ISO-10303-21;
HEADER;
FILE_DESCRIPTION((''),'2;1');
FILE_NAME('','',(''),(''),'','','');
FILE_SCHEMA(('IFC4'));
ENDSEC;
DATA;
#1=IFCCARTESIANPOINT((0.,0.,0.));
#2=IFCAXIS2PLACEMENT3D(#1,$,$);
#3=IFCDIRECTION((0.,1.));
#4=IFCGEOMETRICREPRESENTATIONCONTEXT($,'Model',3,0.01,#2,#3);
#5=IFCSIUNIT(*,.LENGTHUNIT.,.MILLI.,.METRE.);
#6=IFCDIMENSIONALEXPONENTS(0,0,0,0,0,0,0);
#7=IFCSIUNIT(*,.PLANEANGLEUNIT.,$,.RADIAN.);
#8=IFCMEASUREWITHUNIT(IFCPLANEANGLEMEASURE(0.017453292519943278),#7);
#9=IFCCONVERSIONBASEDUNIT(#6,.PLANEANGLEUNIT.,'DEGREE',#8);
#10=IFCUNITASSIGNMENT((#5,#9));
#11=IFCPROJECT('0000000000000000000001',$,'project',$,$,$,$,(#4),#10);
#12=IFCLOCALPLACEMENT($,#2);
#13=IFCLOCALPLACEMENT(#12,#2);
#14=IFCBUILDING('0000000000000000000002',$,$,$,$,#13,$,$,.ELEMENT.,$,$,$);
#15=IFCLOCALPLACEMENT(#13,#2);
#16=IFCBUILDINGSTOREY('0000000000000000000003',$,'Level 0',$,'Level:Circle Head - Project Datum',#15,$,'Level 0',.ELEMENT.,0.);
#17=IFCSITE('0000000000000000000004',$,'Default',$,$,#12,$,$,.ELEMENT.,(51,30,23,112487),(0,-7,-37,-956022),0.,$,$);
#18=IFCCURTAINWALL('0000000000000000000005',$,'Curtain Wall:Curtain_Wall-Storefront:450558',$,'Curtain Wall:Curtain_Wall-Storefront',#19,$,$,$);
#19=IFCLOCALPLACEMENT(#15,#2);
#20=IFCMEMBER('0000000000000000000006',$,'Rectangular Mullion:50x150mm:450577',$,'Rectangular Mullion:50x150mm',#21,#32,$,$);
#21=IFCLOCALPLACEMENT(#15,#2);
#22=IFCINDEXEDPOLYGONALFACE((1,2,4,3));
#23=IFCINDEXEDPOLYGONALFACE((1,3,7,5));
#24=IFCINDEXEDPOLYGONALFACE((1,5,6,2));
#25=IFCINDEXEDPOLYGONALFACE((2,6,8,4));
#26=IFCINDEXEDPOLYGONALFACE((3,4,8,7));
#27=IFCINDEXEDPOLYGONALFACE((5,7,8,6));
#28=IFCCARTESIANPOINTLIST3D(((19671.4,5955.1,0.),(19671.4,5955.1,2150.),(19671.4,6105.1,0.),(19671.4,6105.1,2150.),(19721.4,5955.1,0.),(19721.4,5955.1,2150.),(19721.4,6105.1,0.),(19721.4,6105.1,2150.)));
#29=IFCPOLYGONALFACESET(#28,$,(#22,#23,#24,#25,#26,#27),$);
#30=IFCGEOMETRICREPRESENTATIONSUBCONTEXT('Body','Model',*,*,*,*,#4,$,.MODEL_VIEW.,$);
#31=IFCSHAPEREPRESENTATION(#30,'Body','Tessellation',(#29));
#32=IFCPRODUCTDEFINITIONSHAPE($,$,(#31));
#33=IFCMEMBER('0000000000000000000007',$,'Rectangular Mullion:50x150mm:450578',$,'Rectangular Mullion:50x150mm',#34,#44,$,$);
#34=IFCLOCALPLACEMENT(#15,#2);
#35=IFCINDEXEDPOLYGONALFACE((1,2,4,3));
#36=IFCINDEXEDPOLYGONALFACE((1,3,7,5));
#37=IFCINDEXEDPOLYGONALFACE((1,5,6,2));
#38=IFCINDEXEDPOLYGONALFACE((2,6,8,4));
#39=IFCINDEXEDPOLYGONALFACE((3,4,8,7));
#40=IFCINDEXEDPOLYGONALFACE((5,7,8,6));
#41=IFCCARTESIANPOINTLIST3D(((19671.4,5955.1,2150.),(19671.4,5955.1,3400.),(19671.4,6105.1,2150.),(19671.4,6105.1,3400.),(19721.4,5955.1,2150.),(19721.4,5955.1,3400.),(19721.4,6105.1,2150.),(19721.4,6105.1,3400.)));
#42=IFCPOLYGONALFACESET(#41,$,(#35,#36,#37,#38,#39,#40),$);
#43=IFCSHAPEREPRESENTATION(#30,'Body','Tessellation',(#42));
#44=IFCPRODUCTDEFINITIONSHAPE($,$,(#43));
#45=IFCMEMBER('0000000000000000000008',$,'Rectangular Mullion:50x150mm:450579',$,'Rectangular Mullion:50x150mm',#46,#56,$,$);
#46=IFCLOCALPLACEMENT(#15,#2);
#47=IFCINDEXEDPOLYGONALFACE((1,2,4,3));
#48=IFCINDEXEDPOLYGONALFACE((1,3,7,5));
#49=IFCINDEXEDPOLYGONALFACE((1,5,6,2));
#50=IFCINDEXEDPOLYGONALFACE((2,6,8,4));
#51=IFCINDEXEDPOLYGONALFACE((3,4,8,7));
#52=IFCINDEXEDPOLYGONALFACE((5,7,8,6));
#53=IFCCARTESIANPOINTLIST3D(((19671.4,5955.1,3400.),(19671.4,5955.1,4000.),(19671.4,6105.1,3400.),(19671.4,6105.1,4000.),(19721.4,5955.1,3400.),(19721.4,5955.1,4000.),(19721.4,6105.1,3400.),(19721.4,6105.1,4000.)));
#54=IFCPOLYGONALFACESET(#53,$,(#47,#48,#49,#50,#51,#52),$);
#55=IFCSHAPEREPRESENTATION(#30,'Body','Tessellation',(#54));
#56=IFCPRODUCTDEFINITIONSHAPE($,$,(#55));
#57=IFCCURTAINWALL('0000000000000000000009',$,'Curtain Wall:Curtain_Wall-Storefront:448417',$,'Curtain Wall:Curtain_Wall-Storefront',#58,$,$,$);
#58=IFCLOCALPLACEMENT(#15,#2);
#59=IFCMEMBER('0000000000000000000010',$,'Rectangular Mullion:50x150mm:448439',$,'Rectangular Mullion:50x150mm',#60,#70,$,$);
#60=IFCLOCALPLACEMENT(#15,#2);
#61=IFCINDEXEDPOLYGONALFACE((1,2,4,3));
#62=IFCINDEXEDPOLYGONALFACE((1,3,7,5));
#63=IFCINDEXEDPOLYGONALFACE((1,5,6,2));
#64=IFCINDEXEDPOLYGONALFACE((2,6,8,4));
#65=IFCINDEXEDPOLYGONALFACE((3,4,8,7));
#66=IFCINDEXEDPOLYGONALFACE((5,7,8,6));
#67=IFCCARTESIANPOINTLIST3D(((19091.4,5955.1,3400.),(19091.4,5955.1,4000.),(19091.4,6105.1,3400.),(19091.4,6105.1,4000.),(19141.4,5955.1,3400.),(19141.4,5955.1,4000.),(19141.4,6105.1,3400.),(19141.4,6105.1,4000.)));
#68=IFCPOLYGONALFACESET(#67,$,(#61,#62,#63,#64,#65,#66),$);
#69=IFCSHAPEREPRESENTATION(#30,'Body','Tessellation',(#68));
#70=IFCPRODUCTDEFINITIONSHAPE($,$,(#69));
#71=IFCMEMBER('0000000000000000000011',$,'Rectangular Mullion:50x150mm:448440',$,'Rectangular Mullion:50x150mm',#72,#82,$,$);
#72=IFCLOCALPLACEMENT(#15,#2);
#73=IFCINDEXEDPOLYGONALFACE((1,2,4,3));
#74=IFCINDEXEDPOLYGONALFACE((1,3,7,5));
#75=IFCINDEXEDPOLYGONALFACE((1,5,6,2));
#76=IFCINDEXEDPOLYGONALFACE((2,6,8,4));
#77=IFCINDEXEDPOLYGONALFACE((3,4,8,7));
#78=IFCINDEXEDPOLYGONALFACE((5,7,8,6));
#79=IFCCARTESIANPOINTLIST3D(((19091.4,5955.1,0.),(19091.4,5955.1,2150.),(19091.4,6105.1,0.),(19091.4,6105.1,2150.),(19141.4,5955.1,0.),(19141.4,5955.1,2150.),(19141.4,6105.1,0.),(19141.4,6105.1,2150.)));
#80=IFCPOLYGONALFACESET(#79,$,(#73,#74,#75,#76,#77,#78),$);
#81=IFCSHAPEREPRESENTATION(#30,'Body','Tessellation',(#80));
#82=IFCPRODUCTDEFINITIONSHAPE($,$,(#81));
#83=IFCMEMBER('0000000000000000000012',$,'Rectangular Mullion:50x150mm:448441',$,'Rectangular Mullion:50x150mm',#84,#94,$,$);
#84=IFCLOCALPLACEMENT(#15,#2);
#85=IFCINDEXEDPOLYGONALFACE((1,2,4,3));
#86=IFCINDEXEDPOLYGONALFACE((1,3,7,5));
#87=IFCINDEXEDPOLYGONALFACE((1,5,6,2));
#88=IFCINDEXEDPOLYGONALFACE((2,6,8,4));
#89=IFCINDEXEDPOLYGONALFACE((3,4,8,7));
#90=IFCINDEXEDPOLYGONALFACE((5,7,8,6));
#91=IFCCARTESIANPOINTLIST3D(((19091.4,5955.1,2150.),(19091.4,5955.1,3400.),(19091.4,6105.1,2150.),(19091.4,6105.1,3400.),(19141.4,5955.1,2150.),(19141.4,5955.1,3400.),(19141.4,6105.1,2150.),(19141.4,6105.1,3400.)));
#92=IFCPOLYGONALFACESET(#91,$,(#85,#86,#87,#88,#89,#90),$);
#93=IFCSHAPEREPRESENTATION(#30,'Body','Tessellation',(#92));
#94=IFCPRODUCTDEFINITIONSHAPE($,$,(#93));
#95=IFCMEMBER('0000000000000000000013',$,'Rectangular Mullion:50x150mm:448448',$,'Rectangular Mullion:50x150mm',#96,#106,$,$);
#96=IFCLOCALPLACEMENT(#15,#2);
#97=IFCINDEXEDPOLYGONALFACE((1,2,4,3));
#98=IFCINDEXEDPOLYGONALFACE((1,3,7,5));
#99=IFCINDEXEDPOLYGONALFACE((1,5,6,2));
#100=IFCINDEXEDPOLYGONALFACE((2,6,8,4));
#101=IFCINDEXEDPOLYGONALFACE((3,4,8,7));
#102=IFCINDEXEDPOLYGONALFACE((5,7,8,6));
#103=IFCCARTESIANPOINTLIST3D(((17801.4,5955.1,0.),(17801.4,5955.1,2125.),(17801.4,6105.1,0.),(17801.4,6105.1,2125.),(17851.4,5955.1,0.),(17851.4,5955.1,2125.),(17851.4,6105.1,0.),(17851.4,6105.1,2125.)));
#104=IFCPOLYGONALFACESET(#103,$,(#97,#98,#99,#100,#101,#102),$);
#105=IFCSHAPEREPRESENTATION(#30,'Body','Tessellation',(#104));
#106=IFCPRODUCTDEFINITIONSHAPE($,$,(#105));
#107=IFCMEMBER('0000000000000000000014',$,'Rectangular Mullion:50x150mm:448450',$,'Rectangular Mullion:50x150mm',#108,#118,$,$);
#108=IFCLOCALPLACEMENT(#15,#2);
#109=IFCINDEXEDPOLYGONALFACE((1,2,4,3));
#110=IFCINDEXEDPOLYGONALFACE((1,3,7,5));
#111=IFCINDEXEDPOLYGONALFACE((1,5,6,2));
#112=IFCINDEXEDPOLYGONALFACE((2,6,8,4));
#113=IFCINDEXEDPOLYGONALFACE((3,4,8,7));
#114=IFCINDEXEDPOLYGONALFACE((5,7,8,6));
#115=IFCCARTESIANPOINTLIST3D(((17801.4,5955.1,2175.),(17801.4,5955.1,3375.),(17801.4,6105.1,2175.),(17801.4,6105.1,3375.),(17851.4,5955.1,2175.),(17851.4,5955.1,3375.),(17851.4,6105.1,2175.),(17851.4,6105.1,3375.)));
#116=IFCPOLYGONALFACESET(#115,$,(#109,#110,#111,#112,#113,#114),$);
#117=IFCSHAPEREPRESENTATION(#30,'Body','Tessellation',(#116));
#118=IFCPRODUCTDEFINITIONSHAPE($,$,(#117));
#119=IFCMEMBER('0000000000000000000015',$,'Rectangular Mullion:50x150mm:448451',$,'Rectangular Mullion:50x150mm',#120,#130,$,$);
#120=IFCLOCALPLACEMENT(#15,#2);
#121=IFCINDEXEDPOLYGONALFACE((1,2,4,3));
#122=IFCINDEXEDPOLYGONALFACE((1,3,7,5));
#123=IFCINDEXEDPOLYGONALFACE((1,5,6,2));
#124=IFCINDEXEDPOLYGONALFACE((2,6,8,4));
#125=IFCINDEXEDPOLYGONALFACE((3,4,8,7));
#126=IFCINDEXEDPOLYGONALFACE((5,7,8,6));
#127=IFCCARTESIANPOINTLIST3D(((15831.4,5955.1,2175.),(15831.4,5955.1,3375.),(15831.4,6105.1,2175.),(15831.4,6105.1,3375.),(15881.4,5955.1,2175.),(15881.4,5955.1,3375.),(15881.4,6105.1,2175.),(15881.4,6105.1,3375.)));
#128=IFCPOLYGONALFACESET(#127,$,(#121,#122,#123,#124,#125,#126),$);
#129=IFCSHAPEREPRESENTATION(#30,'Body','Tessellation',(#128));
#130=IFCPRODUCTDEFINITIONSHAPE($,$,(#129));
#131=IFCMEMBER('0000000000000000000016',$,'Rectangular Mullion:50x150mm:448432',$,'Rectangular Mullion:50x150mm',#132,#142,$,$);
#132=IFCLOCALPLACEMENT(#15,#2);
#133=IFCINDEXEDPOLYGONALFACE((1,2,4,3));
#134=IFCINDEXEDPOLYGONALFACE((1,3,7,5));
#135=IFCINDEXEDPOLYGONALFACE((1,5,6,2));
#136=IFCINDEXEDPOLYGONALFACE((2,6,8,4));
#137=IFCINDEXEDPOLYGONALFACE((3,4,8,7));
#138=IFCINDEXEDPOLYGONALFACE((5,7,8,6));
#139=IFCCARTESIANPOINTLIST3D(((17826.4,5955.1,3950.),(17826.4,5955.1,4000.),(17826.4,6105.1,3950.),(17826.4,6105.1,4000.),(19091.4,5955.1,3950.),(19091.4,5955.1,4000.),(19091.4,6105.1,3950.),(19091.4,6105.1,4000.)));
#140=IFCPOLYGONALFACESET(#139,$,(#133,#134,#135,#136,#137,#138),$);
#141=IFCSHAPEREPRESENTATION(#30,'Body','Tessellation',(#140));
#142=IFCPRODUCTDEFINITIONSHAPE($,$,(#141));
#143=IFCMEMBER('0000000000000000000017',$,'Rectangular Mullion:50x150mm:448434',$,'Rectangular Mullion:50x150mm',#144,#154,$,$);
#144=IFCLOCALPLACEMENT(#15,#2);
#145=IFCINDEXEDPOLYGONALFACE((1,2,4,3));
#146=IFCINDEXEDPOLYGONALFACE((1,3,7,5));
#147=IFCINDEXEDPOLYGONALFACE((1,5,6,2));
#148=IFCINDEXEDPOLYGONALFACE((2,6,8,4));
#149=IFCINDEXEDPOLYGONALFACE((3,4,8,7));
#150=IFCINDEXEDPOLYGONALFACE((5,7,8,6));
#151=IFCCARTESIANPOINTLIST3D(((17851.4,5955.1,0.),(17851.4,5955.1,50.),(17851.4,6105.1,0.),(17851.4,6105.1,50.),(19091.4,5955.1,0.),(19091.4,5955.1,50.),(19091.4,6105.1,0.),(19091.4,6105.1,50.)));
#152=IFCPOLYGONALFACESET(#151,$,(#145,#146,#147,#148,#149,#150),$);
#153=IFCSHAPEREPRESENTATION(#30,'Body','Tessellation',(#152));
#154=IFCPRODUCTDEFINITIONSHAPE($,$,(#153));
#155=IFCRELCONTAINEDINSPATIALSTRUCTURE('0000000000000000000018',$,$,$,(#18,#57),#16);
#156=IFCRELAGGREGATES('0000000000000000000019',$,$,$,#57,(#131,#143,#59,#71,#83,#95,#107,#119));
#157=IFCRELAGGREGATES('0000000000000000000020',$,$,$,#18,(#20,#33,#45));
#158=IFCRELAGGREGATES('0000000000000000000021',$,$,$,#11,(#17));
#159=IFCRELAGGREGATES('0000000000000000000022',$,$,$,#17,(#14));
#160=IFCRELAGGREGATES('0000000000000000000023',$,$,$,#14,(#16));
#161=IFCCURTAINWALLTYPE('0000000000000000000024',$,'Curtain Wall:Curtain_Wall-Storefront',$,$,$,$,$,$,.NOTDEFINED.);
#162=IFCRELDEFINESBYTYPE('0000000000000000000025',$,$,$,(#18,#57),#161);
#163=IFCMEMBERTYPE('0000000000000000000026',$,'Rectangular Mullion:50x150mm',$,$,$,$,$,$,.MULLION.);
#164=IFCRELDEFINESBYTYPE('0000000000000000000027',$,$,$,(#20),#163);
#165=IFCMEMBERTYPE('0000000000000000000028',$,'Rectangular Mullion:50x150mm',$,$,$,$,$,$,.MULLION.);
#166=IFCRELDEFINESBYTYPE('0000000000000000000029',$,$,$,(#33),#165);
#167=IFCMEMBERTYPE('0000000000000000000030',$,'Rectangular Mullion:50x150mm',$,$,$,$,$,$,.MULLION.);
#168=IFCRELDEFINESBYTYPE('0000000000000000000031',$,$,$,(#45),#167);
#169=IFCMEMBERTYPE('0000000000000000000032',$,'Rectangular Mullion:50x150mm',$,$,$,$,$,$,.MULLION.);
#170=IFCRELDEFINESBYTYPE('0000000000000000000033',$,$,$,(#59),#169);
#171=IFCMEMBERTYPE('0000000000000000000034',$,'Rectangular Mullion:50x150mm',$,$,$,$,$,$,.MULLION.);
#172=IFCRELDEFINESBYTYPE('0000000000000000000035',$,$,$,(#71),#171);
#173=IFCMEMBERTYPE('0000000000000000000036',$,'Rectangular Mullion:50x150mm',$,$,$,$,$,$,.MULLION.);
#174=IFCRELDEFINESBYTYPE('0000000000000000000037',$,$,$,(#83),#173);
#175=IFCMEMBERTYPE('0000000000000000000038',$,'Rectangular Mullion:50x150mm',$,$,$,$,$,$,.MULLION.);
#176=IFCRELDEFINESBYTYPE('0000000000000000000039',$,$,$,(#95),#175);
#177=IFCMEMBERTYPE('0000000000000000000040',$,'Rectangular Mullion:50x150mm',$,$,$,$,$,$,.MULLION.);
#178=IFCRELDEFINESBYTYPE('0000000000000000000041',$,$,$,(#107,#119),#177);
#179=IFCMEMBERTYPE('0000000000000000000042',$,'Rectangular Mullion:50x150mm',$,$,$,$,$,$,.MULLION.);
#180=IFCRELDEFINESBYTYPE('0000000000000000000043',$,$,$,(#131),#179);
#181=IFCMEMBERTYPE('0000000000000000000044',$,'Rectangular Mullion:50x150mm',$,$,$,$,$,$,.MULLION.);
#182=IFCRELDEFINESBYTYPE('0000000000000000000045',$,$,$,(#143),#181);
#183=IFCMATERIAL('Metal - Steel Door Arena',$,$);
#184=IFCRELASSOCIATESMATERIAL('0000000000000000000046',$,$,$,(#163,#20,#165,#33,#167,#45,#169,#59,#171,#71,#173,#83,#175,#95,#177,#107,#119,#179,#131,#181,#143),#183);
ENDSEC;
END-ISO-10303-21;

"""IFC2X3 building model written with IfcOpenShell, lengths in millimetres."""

from ifc_helpers import new_model, entity, si_unit, converted_unit, direction, frame, origin, origin_2d_with_axis, place, context, subcontext, project, spatial, rectangle, extrude, source, transform, mapped, material, type_object, type_shapes, element, aggregate, save


model = new_model("IFC2X3")

# Units and contexts
model_context = context("Model", 3, precision=0.01, world=origin(), true_north=direction((0.0, 1.0)))
body_context = subcontext(model_context, "Body", "Model", "MODEL_VIEW")
ifc_project = project(units=[si_unit("LENGTHUNIT", "METRE", prefix="MILLI"), converted_unit("PLANEANGLEUNIT", "DEGREE", entity("IfcPlaneAngleMeasure", 0.017453292519943278), si_unit("PLANEANGLEUNIT", "RADIAN"), dimensions=[0, 0, 0, 0, 0, 0, 0])], contexts=[model_context])

# Site, building, storey
site_placement = place(None, origin())
site = spatial("IfcSite", under=ifc_project, at=site_placement, Name="Default", CompositionType="ELEMENT", RefLatitude=(51, 30, 23, 112487), RefLongitude=(0, -7, -37, -956022), RefElevation=0.0)
building_placement = place(site_placement, origin())
building = spatial("IfcBuilding", under=site, at=building_placement, CompositionType="ELEMENT")
storey_placement = place(building_placement, origin())
storey = spatial("IfcBuildingStorey", under=building, at=storey_placement, Name="Level 0", ObjectType="Level:Circle Head - Project Datum", LongName="Level 0", CompositionType="ELEMENT", Elevation=0.0)

# Curtain walls, members
curtain_wall_type = type_object("IfcCurtainWallType", Name="Curtain Wall:Curtain_Wall-Storefront", PredefinedType="NOTDEFINED")
curtain_wall_1_placement = place(storey_placement, origin())
curtain_wall_1 = element("IfcCurtainWall", 1, at=curtain_wall_1_placement, inside=storey, type_object=curtain_wall_type, Name="Curtain Wall:Curtain_Wall-Storefront:450558", ObjectType="Curtain Wall:Curtain_Wall-Storefront")
ifc_material_1 = material(Name="Metal - Steel Door Arena")
member_type_1 = type_object("IfcMemberType", Name="Rectangular Mullion:50x150mm", PredefinedType="MULLION", material=ifc_material_1)
shared_shape_1 = source(origin(), body_context, "Body", "SweptSolid", [
    extrude(rectangle(XDim=50.0, YDim=150.0, at=origin_2d_with_axis()), frame((-25.0, 0.0, -2150.0), z_axis=(0.0, 0.0, 1.0), x_axis=(-1.0, 0.0, 0.0)), (0.0, 0.0, 1.0), 2150.0),
])
type_shapes(member_type_1, [shared_shape_1])
member_1_placement = place(curtain_wall_1_placement, frame((19671.4, 6030.1, 0.0), z_axis=(0.0, 0.0, -1.0), x_axis=(-1.0, 0.0, 0.0)))
member_1 = element("IfcMember", 2, at=member_1_placement, type_object=member_type_1, material=ifc_material_1, Name="Rectangular Mullion:50x150mm:450577", ObjectType="Rectangular Mullion:50x150mm", context=body_context, shape_type="MappedRepresentation", body=[
    mapped(shared_shape_1, transform((0.0, 0.0, 0.0), scale=1.0)),
])
member_type_2 = type_object("IfcMemberType", Name="Rectangular Mullion:50x150mm", PredefinedType="MULLION", material=ifc_material_1)
shared_shape_2 = source(origin(), body_context, "Body", "SweptSolid", [
    extrude(rectangle(XDim=50.0, YDim=150.0, at=origin_2d_with_axis()), frame((-25.0, 0.0, -1250.0), z_axis=(0.0, 0.0, 1.0), x_axis=(-1.0, 0.0, 0.0)), (0.0, 0.0, 1.0), 1250.0),
])
type_shapes(member_type_2, [shared_shape_2])
member_2_placement = place(curtain_wall_1_placement, frame((19671.4, 6030.1, 2150.0), z_axis=(0.0, 0.0, -1.0), x_axis=(-1.0, 0.0, 0.0)))
member_2 = element("IfcMember", 3, at=member_2_placement, type_object=member_type_2, material=ifc_material_1, Name="Rectangular Mullion:50x150mm:450578", ObjectType="Rectangular Mullion:50x150mm", context=body_context, shape_type="MappedRepresentation", body=[
    mapped(shared_shape_2, transform((0.0, 0.0, 0.0), scale=1.0)),
])
member_type_3 = type_object("IfcMemberType", Name="Rectangular Mullion:50x150mm", PredefinedType="MULLION", material=ifc_material_1)
shared_shape_3 = source(origin(), body_context, "Body", "SweptSolid", [
    extrude(rectangle(XDim=50.0, YDim=150.0, at=origin_2d_with_axis()), frame((-25.0, 0.0, -600.0), z_axis=(0.0, 0.0, 1.0), x_axis=(-1.0, 0.0, 0.0)), (0.0, 0.0, 1.0), 600.0),
])
type_shapes(member_type_3, [shared_shape_3])
member_3_placement = place(curtain_wall_1_placement, frame((19671.4, 6030.1, 3400.0), z_axis=(0.0, 0.0, -1.0), x_axis=(-1.0, 0.0, 0.0)))
member_3 = element("IfcMember", 4, at=member_3_placement, type_object=member_type_3, material=ifc_material_1, Name="Rectangular Mullion:50x150mm:450579", ObjectType="Rectangular Mullion:50x150mm", context=body_context, shape_type="MappedRepresentation", body=[
    mapped(shared_shape_3, transform((0.0, 0.0, 0.0), scale=1.0)),
])
curtain_wall_2_placement = place(storey_placement, origin())
curtain_wall_2 = element("IfcCurtainWall", 5, at=curtain_wall_2_placement, inside=storey, type_object=curtain_wall_type, Name="Curtain Wall:Curtain_Wall-Storefront:448417", ObjectType="Curtain Wall:Curtain_Wall-Storefront")
member_type_4 = type_object("IfcMemberType", Name="Rectangular Mullion:50x150mm", PredefinedType="MULLION", material=ifc_material_1)
shared_shape_4 = source(origin(), body_context, "Body", "SweptSolid", [
    extrude(rectangle(XDim=50.0, YDim=150.0, at=origin_2d_with_axis()), frame((-25.0, 0.0, -600.0), z_axis=(0.0, 0.0, 1.0), x_axis=(-1.0, 0.0, 0.0)), (0.0, 0.0, 1.0), 600.0),
])
type_shapes(member_type_4, [shared_shape_4])
member_4_placement = place(curtain_wall_2_placement, frame((19141.4, 6030.1, 4000.0)))
member_4 = element("IfcMember", 6, at=member_4_placement, type_object=member_type_4, material=ifc_material_1, Name="Rectangular Mullion:50x150mm:448439", ObjectType="Rectangular Mullion:50x150mm", context=body_context, shape_type="MappedRepresentation", body=[
    mapped(shared_shape_4, transform((0.0, 0.0, 0.0), scale=1.0)),
])
member_type_5 = type_object("IfcMemberType", Name="Rectangular Mullion:50x150mm", PredefinedType="MULLION", material=ifc_material_1)
shared_shape_5 = source(origin(), body_context, "Body", "SweptSolid", [
    extrude(rectangle(XDim=50.0, YDim=150.0, at=origin_2d_with_axis()), frame((-25.0, 0.0, -2150.0), z_axis=(0.0, 0.0, 1.0), x_axis=(-1.0, 0.0, 0.0)), (0.0, 0.0, 1.0), 2150.0),
])
type_shapes(member_type_5, [shared_shape_5])
member_5_placement = place(curtain_wall_2_placement, frame((19141.4, 6030.1, 2150.0)))
member_5 = element("IfcMember", 7, at=member_5_placement, type_object=member_type_5, material=ifc_material_1, Name="Rectangular Mullion:50x150mm:448440", ObjectType="Rectangular Mullion:50x150mm", context=body_context, shape_type="MappedRepresentation", body=[
    mapped(shared_shape_5, transform((0.0, 0.0, 0.0), scale=1.0)),
])
member_type_6 = type_object("IfcMemberType", Name="Rectangular Mullion:50x150mm", PredefinedType="MULLION", material=ifc_material_1)
shared_shape_6 = source(origin(), body_context, "Body", "SweptSolid", [
    extrude(rectangle(XDim=50.0, YDim=150.0, at=origin_2d_with_axis()), frame((-25.0, 0.0, -1250.0), z_axis=(0.0, 0.0, 1.0), x_axis=(-1.0, 0.0, 0.0)), (0.0, 0.0, 1.0), 1250.0),
])
type_shapes(member_type_6, [shared_shape_6])
member_6_placement = place(curtain_wall_2_placement, frame((19141.4, 6030.1, 3400.0)))
member_6 = element("IfcMember", 8, at=member_6_placement, type_object=member_type_6, material=ifc_material_1, Name="Rectangular Mullion:50x150mm:448441", ObjectType="Rectangular Mullion:50x150mm", context=body_context, shape_type="MappedRepresentation", body=[
    mapped(shared_shape_6, transform((0.0, 0.0, 0.0), scale=1.0)),
])
member_type_7 = type_object("IfcMemberType", Name="Rectangular Mullion:50x150mm", PredefinedType="MULLION", material=ifc_material_1)
shared_shape_7 = source(origin(), body_context, "Body", "SweptSolid", [
    extrude(rectangle(XDim=50.0, YDim=150.0, at=origin_2d_with_axis()), frame((0.0, 0.0, -2125.0), z_axis=(0.0, 0.0, 1.0), x_axis=(-1.0, 0.0, 0.0)), (0.0, 0.0, 1.0), 2125.0),
])
type_shapes(member_type_7, [shared_shape_7])
member_7_placement = place(curtain_wall_2_placement, frame((17826.4, 6030.1, 0.0), z_axis=(0.0, 0.0, -1.0), x_axis=(-1.0, 0.0, 0.0)))
member_7 = element("IfcMember", 9, at=member_7_placement, type_object=member_type_7, material=ifc_material_1, Name="Rectangular Mullion:50x150mm:448448", ObjectType="Rectangular Mullion:50x150mm", context=body_context, shape_type="MappedRepresentation", body=[
    mapped(shared_shape_7, transform((0.0, 0.0, 0.0), scale=1.0)),
])
member_type_8 = type_object("IfcMemberType", Name="Rectangular Mullion:50x150mm", PredefinedType="MULLION", material=ifc_material_1)
shared_shape_8 = source(origin(), body_context, "Body", "SweptSolid", [
    extrude(rectangle(XDim=50.0, YDim=150.0, at=origin_2d_with_axis()), frame((0.0, 0.0, -1200.0), z_axis=(0.0, 0.0, 1.0), x_axis=(-1.0, 0.0, 0.0)), (0.0, 0.0, 1.0), 1200.0),
])
type_shapes(member_type_8, [shared_shape_8])
member_8_placement = place(curtain_wall_2_placement, frame((17826.4, 6030.1, 2175.0), z_axis=(0.0, 0.0, -1.0), x_axis=(-1.0, 0.0, 0.0)))
member_8 = element("IfcMember", 10, at=member_8_placement, type_object=member_type_8, material=ifc_material_1, Name="Rectangular Mullion:50x150mm:448450", ObjectType="Rectangular Mullion:50x150mm", context=body_context, shape_type="MappedRepresentation", body=[
    mapped(shared_shape_8, transform((0.0, 0.0, 0.0), scale=1.0)),
])
member_9_placement = place(curtain_wall_2_placement, frame((15856.4, 6030.1, 2175.0), z_axis=(0.0, 0.0, -1.0), x_axis=(-1.0, 0.0, 0.0)))
member_9 = element("IfcMember", 11, at=member_9_placement, type_object=member_type_8, material=ifc_material_1, Name="Rectangular Mullion:50x150mm:448451", ObjectType="Rectangular Mullion:50x150mm", context=body_context, shape_type="MappedRepresentation", body=[
    mapped(shared_shape_8, transform((0.0, 0.0, 0.0), scale=1.0)),
])
member_type_9 = type_object("IfcMemberType", Name="Rectangular Mullion:50x150mm", PredefinedType="MULLION", material=ifc_material_1)
shared_shape_9 = source(origin(), body_context, "Body", "SweptSolid", [
    extrude(rectangle(XDim=50.0, YDim=150.0, at=origin_2d_with_axis()), frame((-25.0, 0.0, -1265.0), z_axis=(0.0, 0.0, 1.0), x_axis=(-1.0, 0.0, 0.0)), (0.0, 0.0, 1.0), 1265.0),
])
type_shapes(member_type_9, [shared_shape_9])
member_10_placement = place(curtain_wall_2_placement, frame((17826.4, 6030.1, 4000.0), z_axis=(-1.0, 0.0, 0.0), x_axis=(0.0, 0.0, 1.0)))
member_10 = element("IfcMember", 12, at=member_10_placement, type_object=member_type_9, material=ifc_material_1, Name="Rectangular Mullion:50x150mm:448432", ObjectType="Rectangular Mullion:50x150mm", context=body_context, shape_type="MappedRepresentation", body=[
    mapped(shared_shape_9, transform((0.0, 0.0, 0.0), scale=1.0)),
])
member_type_10 = type_object("IfcMemberType", Name="Rectangular Mullion:50x150mm", PredefinedType="MULLION", material=ifc_material_1)
shared_shape_10 = source(origin(), body_context, "Body", "SweptSolid", [
    extrude(rectangle(XDim=50.0, YDim=150.0, at=origin_2d_with_axis()), frame((-25.0, 0.0, -1240.0), z_axis=(0.0, 0.0, 1.0), x_axis=(-1.0, 0.0, 0.0)), (0.0, 0.0, 1.0), 1240.0),
])
type_shapes(member_type_10, [shared_shape_10])
member_11_placement = place(curtain_wall_2_placement, frame((19091.4, 6030.1, 0.0), z_axis=(1.0, 0.0, 0.0), x_axis=(0.0, 0.0, -1.0)))
member_11 = element("IfcMember", 13, at=member_11_placement, type_object=member_type_10, material=ifc_material_1, Name="Rectangular Mullion:50x150mm:448434", ObjectType="Rectangular Mullion:50x150mm", context=body_context, shape_type="MappedRepresentation", body=[
    mapped(shared_shape_10, transform((0.0, 0.0, 0.0), scale=1.0)),
])

aggregate(curtain_wall_2, [member_10, member_11, member_4, member_5, member_6, member_7, member_8, member_9])
aggregate(curtain_wall_1, [member_1, member_2, member_3])

save(model, "model.ifc")
